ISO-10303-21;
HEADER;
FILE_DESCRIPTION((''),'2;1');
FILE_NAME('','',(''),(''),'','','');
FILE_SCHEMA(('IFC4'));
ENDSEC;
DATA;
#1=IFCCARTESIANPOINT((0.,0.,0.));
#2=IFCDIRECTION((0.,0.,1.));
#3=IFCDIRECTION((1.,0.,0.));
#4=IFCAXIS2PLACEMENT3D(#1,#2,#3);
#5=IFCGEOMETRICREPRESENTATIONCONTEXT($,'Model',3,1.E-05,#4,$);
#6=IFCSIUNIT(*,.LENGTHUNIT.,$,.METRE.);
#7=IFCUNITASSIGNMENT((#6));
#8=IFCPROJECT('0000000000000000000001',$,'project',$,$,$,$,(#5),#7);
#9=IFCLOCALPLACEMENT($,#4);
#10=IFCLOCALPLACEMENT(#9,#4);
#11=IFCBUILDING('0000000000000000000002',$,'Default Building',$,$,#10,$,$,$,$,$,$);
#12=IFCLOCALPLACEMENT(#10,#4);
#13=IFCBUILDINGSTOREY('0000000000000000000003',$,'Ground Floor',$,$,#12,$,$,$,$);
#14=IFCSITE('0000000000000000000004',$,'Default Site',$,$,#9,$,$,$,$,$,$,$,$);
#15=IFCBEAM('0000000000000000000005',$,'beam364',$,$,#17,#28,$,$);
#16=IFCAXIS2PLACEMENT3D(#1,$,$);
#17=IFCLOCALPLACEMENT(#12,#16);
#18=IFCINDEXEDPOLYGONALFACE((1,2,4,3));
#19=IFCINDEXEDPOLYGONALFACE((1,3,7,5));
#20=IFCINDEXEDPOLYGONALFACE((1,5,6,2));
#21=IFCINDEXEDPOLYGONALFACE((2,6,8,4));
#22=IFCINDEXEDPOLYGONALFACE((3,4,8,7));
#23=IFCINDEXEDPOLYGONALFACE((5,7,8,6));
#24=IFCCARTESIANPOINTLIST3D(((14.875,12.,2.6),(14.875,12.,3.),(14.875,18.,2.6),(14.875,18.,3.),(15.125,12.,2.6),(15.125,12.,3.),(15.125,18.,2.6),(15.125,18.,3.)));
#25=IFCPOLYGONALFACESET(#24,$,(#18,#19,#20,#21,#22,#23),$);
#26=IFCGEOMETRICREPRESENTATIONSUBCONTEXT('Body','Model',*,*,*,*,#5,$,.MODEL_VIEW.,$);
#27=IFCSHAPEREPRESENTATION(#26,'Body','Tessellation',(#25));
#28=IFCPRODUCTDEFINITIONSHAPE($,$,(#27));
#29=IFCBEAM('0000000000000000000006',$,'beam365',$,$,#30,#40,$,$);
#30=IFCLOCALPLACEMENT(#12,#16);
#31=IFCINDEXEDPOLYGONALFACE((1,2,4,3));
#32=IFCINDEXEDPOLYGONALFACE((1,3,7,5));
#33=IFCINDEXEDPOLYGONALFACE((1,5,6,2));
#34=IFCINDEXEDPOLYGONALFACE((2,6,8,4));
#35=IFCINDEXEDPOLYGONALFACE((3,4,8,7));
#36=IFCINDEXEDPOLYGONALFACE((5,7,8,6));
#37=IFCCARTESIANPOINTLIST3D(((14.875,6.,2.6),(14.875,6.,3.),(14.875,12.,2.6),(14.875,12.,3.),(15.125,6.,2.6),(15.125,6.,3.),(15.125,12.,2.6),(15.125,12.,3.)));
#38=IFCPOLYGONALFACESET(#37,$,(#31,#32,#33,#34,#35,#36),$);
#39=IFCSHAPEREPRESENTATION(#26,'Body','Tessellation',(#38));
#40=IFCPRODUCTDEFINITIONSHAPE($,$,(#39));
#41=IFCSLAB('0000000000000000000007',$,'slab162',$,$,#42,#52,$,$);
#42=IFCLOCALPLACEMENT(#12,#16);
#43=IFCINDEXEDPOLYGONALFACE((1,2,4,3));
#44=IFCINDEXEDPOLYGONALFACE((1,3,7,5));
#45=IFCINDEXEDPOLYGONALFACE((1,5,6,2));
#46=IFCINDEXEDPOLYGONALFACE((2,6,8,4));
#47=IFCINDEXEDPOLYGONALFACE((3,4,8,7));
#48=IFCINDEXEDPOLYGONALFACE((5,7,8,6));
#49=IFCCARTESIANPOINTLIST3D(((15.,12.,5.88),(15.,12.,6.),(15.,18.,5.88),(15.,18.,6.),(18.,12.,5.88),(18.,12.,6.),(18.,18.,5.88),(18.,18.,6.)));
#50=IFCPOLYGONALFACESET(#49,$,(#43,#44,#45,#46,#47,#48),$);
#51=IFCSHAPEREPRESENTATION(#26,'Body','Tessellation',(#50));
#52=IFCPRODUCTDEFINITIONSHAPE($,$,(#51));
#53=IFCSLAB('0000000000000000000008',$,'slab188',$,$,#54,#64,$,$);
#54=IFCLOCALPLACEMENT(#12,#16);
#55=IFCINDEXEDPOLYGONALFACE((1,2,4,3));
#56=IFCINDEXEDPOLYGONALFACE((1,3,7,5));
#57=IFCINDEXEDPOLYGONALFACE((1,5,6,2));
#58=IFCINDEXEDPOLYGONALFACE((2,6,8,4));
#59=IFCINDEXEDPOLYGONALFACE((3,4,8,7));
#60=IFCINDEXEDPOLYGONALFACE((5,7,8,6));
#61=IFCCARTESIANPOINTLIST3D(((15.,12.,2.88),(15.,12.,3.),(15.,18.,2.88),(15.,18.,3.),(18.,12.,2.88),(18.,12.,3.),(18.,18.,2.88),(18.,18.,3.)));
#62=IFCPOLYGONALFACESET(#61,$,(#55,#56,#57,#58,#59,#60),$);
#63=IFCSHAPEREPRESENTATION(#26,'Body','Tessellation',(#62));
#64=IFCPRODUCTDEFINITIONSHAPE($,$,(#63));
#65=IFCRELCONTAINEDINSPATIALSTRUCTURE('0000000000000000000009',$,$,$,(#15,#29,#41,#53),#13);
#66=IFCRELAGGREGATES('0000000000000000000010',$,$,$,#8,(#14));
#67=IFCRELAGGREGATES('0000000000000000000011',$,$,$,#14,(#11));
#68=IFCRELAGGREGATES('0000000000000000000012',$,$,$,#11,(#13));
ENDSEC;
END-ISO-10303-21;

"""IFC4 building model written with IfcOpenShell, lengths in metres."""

from ifc_helpers import new_model, si_unit, frame, origin_with_axes, place, context, subcontext, project, spatial, indexed_curve, outline, extrude, element, save


model = new_model("IFC4")

# Units and contexts
model_context = context("Model", 3, precision=1e-05, world=origin_with_axes())
body_context = subcontext(model_context, "Body", "Model", "MODEL_VIEW")
ifc_project = project(units=[si_unit("LENGTHUNIT", "METRE")], contexts=[model_context])

# Site, building, storey
site_placement = place(None, origin_with_axes())
site = spatial("IfcSite", under=ifc_project, at=site_placement, Name="Default Site")
building_placement = place(site_placement, origin_with_axes())
building = spatial("IfcBuilding", under=site, at=building_placement, Name="Default Building")
storey_placement = place(building_placement, origin_with_axes())
storey = spatial("IfcBuildingStorey", under=building, at=storey_placement, Name="Ground Floor")

# Beams
for number, where, z_axis, x_axis, name in (
    (1, (14.875, 18.0, 2.6), (0.0, 0.0, 1.0), (0.0, -1.0, 0.0), "beam364"),
    (2, (14.875, 12.0, 2.6), (0.0, 0.0, 1.0), (0.0, -1.0, 0.0), "beam365"),
):
    element("IfcBeam", number, at=place(storey_placement, frame(where, z_axis=z_axis, x_axis=x_axis)), inside=storey, Name=name, context=body_context, shape_type="SweptSolid", body=[
        extrude(outline(indexed_curve([(0.0, 0.0), (0.0, 0.25), (6.0, 0.25), (6.0, 0.0), (0.0, 0.0)], self_intersect=False)), origin_with_axes(), (0.0, 0.0, 1.0), 0.4),
    ])

# Slabs
for number, where, z_axis, x_axis, name in (
    (3, (15.0, 12.0, 5.88), (0.0, 0.0, 1.0), (1.0, 0.0, 0.0), "slab162"),
    (4, (15.0, 12.0, 2.88), (0.0, 0.0, 1.0), (1.0, 0.0, 0.0), "slab188"),
):
    element("IfcSlab", number, at=place(storey_placement, frame(where, z_axis=z_axis, x_axis=x_axis)), inside=storey, Name=name, context=body_context, shape_type="SweptSolid", body=[
        extrude(outline(indexed_curve([(0.0, 0.0), (0.0, 6.0), (3.0, 6.0), (3.0, 0.0), (0.0, 0.0)], self_intersect=False)), origin_with_axes(), (0.0, 0.0, 1.0), 0.12),
    ])

save(model, "model.ifc")
